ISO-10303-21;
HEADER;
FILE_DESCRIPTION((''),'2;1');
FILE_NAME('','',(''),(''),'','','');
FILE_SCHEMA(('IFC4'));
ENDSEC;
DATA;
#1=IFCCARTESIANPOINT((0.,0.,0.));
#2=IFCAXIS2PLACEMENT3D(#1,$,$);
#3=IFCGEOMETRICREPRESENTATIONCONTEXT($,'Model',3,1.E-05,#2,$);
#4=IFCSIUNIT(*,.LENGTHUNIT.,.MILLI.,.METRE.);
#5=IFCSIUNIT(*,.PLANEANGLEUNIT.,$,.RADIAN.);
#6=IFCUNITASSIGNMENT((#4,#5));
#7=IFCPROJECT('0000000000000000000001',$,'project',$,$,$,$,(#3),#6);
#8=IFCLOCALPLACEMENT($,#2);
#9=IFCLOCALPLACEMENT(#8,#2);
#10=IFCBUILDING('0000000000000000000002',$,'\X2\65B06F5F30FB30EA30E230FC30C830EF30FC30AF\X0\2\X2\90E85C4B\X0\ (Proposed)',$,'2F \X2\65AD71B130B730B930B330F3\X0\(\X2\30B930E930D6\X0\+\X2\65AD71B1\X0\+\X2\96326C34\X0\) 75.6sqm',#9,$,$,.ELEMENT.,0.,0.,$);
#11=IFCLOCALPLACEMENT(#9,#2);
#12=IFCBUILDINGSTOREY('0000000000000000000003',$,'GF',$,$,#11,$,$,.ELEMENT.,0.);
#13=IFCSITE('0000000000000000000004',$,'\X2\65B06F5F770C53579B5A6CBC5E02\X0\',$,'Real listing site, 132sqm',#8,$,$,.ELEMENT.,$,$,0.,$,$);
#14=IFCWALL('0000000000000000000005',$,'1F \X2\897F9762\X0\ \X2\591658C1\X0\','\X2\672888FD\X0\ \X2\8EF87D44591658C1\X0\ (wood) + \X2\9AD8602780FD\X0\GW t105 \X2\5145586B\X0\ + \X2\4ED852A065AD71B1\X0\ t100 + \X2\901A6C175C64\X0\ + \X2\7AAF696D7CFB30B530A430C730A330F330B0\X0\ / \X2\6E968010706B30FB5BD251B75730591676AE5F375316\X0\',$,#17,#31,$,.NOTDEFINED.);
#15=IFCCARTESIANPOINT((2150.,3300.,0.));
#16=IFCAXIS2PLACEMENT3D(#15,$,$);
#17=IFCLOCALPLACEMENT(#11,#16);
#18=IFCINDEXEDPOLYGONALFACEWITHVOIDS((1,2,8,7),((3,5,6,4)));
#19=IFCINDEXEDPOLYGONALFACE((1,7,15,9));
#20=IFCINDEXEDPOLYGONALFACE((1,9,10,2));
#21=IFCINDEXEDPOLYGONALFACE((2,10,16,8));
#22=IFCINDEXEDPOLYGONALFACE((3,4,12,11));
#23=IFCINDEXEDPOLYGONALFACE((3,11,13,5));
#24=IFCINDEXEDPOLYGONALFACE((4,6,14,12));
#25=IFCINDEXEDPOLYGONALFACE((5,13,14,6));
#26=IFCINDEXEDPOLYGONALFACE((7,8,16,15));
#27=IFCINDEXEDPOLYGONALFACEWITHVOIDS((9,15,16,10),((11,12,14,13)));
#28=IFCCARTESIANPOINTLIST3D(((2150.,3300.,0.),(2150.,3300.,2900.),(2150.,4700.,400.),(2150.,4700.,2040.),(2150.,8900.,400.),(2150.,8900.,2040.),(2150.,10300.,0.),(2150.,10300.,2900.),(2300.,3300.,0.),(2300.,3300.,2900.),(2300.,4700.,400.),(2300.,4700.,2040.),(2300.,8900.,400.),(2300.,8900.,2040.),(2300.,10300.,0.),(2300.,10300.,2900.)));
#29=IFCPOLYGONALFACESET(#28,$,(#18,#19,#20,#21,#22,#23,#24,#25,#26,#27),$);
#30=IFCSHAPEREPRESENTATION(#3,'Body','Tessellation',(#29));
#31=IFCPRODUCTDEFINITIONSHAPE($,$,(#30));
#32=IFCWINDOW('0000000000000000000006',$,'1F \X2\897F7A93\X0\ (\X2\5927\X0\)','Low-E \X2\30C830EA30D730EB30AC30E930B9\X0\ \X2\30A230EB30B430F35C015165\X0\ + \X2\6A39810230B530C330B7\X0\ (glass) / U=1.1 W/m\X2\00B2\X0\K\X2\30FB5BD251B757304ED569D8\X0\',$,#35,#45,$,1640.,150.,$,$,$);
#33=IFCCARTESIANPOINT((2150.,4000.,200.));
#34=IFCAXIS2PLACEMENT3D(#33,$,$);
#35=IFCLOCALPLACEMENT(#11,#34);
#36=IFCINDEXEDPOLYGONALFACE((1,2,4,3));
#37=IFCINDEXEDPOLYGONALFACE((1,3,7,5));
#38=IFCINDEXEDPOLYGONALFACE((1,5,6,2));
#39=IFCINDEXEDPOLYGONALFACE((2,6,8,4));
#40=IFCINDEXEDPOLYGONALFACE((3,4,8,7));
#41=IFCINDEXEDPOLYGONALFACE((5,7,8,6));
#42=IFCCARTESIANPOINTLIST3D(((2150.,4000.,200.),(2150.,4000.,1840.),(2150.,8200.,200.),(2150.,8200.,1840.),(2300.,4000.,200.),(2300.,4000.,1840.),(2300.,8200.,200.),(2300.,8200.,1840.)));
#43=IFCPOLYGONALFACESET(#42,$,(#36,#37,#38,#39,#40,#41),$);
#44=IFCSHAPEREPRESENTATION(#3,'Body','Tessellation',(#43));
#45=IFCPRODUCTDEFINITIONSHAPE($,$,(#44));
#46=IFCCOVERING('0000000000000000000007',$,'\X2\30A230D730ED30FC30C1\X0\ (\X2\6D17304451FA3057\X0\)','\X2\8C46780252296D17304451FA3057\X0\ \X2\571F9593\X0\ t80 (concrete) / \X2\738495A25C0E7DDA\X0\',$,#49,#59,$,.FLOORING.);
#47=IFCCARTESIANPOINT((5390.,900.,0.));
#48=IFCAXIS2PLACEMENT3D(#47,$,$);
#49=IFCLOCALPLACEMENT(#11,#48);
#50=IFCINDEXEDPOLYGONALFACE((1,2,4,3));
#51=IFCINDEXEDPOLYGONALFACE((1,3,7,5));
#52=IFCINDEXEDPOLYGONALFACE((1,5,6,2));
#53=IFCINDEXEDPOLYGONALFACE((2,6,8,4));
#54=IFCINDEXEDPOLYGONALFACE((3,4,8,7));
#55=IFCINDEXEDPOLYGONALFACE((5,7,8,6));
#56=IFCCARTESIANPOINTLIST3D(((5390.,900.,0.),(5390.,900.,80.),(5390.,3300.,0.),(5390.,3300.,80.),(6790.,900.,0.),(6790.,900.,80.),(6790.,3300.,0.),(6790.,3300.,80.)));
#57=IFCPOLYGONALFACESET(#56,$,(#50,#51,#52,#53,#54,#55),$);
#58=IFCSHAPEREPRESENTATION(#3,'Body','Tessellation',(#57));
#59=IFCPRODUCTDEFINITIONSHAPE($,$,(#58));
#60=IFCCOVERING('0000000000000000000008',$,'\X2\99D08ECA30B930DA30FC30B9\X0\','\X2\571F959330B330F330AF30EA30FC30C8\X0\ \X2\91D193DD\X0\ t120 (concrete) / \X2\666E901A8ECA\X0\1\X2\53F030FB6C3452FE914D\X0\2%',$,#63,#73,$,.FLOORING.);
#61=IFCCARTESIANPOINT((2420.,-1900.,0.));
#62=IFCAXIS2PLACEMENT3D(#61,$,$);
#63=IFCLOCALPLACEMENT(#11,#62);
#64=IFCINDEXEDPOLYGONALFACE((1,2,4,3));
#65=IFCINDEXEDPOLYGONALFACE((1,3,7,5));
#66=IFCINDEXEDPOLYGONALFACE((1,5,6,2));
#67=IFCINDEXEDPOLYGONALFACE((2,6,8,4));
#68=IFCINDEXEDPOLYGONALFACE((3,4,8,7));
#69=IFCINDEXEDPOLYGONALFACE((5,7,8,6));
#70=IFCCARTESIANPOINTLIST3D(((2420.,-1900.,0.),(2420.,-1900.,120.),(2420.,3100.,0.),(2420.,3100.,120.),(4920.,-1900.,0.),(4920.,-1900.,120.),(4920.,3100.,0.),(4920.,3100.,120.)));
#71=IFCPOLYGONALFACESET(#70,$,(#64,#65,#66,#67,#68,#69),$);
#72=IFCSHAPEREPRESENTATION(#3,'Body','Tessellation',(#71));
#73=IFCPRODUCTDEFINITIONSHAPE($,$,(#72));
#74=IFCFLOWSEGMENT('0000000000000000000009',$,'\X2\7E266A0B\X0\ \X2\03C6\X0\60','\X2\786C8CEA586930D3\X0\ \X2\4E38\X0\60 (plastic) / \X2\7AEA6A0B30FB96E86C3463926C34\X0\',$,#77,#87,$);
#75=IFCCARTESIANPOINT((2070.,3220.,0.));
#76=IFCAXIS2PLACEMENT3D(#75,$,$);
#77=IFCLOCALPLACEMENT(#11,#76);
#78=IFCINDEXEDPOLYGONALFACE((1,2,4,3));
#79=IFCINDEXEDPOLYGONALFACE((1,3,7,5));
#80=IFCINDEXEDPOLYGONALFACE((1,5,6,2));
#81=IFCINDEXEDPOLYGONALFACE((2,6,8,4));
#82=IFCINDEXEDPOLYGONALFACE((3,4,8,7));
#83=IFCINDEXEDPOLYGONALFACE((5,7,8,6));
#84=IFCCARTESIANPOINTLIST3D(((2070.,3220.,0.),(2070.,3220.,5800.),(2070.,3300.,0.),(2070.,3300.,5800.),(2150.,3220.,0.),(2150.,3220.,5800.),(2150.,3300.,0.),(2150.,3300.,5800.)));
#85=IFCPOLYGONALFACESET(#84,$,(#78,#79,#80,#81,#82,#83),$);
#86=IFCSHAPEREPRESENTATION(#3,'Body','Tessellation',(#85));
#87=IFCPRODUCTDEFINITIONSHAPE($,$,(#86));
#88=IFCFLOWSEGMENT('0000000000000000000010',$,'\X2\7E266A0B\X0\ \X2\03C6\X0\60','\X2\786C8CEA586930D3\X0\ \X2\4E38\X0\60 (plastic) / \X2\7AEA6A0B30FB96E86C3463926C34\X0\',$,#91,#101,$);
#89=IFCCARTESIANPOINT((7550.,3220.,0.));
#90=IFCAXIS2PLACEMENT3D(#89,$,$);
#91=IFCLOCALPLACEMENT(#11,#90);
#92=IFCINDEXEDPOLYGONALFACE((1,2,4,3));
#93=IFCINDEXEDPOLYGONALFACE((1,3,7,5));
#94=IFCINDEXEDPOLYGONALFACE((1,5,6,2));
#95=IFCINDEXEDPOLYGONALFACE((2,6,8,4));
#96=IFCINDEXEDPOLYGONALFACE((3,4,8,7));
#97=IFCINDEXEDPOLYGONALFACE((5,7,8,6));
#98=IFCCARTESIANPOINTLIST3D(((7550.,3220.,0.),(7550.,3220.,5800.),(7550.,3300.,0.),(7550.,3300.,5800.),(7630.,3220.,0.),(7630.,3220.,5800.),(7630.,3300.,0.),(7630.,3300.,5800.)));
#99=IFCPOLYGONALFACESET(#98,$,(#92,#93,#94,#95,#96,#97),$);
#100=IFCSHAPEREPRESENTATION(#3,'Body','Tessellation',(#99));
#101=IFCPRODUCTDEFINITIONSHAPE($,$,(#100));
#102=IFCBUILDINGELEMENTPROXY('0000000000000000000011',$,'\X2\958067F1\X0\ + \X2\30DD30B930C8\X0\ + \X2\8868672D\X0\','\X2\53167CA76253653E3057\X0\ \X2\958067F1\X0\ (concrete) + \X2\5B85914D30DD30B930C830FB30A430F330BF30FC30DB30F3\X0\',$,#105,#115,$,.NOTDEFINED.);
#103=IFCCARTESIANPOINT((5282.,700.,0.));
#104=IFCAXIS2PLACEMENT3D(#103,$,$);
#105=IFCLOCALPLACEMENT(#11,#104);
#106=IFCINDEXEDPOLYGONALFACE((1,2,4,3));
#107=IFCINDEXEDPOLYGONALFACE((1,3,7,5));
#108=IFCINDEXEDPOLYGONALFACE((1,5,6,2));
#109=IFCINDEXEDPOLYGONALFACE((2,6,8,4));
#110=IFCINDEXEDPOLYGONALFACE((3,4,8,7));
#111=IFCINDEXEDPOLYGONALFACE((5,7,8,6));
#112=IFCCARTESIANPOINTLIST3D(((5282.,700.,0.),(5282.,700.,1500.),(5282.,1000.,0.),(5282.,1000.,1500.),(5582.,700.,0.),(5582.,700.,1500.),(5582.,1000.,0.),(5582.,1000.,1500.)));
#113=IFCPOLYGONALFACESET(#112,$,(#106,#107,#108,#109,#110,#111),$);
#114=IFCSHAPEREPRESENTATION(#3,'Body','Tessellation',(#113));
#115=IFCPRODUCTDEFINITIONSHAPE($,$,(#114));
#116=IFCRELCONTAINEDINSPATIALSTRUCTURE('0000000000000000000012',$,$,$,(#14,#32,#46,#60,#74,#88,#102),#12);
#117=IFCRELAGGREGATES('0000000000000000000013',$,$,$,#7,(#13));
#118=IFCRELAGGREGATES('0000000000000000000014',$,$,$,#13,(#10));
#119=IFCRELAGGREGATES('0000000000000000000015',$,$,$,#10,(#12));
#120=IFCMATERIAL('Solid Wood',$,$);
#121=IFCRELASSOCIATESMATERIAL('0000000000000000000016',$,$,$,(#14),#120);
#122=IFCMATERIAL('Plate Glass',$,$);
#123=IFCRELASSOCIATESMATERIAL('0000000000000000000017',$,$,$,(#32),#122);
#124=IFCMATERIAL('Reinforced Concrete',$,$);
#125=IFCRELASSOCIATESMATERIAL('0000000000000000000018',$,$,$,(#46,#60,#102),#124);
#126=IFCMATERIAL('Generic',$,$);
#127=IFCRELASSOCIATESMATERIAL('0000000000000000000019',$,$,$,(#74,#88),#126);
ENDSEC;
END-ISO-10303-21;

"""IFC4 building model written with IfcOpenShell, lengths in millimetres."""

from ifc_helpers import new_model, si_unit, frame, frame_2d, origin, place, context, project, spatial, rectangle, extrude, material, element, fill, save


model = new_model("IFC4")

# Units and contexts
model_context = context("Model", 3, precision=1e-05, world=origin())
ifc_project = project(units=[si_unit("LENGTHUNIT", "METRE", prefix="MILLI"), si_unit("PLANEANGLEUNIT", "RADIAN")], contexts=[model_context])

# Site, building, storey
site_placement = place(None, origin())
site = spatial("IfcSite", under=ifc_project, at=site_placement, Name="新潟県南魚沼市", ObjectType="Real listing site, 132sqm", CompositionType="ELEMENT", RefElevation=0.0)
building_placement = place(site_placement, origin())
building = spatial("IfcBuilding", under=site, at=building_placement, Name="新潟・リモートワーク2部屋 (Proposed)", ObjectType="2F 断熱シスコン(スラブ+断熱+防水) 75.6sqm", CompositionType="ELEMENT", ElevationOfRefHeight=0.0, ElevationOfTerrain=0.0)
storey_placement = place(building_placement, origin())
storey = spatial("IfcBuildingStorey", under=building, at=storey_placement, Name="GF", CompositionType="ELEMENT", Elevation=0.0)

# Shared definitions
ifc_material_1 = material(Name="Solid Wood")

# Shared definitions
ifc_material_2 = material(Name="Reinforced Concrete")

# Shared definitions
ifc_material_3 = material(Name="Plate Glass")

# Wall, opening, window
wall_1_placement = place(storey_placement, frame((2150.0, 3300.0, 0.0)))
wall_1 = element("IfcWall", 1, at=wall_1_placement, inside=storey, material=ifc_material_1, Name="1F 西面 外壁", Description="木製 軸組外壁 (wood) + 高性能GW t105 充填 + 付加断熱 t100 + 通気層 + 窯業系サイディング / 準耐火・寒冷地外皮強化", PredefinedType="NOTDEFINED", context=model_context, shape_type="SweptSolid", body=[
    extrude(rectangle(XDim=150.0, YDim=7000.0, at=frame_2d((75.0, 3500.0))), frame((2150.0, 3300.0, 0.0)), (0.0, 0.0, 1.0), 2900.0),
])
opening_1_placement = place(storey_placement, frame((2150.0, 4000.0, 200.0)))
opening_1 = element("IfcOpeningElement", 2, at=opening_1_placement, cuts=wall_1, PredefinedType="NOTDEFINED", context=model_context, shape_type="SweptSolid", body=[
    extrude(rectangle(XDim=150.0, YDim=4200.0, at=frame_2d((75.0, 2100.0))), frame((2150.0, 4000.0, 200.0)), (0.0, 0.0, 1.0), 1640.0),
])
window_1_placement = place(storey_placement, frame((2150.0, 4000.0, 200.0)))
window_1 = element("IfcWindow", 3, at=window_1_placement, inside=storey, material=ifc_material_3, Name="1F 西窓 (大)", Description="Low-E トリプルガラス アルゴン封入 + 樹脂サッシ (glass) / U=1.1 W/m²K・寒冷地仕様", OverallHeight=1640.0, OverallWidth=150.0, context=model_context, shape_type="SweptSolid", body=[
    extrude(rectangle(XDim=150.0, YDim=4200.0, at=frame_2d((75.0, 2100.0))), frame((2150.0, 4000.0, 200.0)), (0.0, 0.0, 1.0), 1640.0),
])
fill(opening_1, window_1)

# Coverings
covering_1_placement = place(storey_placement, frame((5390.0, 900.0, 0.0)))
element("IfcCovering", 4, at=covering_1_placement, inside=storey, material=ifc_material_2, Name="アプローチ (洗い出し)", Description="豆砂利洗い出し 土間 t80 (concrete) / 玄関導線", PredefinedType="FLOORING", context=model_context, shape_type="SweptSolid", body=[
    extrude(rectangle(XDim=1400.0, YDim=2400.0, at=frame_2d((700.0, 1200.0))), frame((5390.0, 900.0, 0.0)), (0.0, 0.0, 1.0), 80.0),
])
covering_2_placement = place(storey_placement, frame((2420.0, -1900.0, 0.0)))
element("IfcCovering", 5, at=covering_2_placement, inside=storey, material=ifc_material_2, Name="駐車スペース", Description="土間コンクリート 金鏝 t120 (concrete) / 普通車1台・水勾配2%", PredefinedType="FLOORING", context=model_context, shape_type="SweptSolid", body=[
    extrude(rectangle(XDim=2500.0, YDim=5000.0, at=frame_2d((1250.0, 2500.0))), frame((2420.0, -1900.0, 0.0)), (0.0, 0.0, 1.0), 120.0),
])

# Flow segments
ifc_material_4 = material(Name="Generic")
flow_segment_1_placement = place(storey_placement, frame((2070.0, 3220.0, 0.0)))
element("IfcFlowSegment", 6, at=flow_segment_1_placement, inside=storey, material=ifc_material_4, Name="縦樋 φ60", Description="硬質塩ビ 丸60 (plastic) / 竪樋・雨水排水", context=model_context, shape_type="SweptSolid", body=[
    extrude(rectangle(XDim=80.0, YDim=80.0, at=frame_2d((40.0, 40.0))), frame((2070.0, 3220.0, 0.0)), (0.0, 0.0, 1.0), 5800.0),
])
flow_segment_2_placement = place(storey_placement, frame((7550.0, 3220.0, 0.0)))
element("IfcFlowSegment", 7, at=flow_segment_2_placement, inside=storey, material=ifc_material_4, Name="縦樋 φ60", Description="硬質塩ビ 丸60 (plastic) / 竪樋・雨水排水", context=model_context, shape_type="SweptSolid", body=[
    extrude(rectangle(XDim=80.0, YDim=80.0, at=frame_2d((40.0, 40.0))), frame((7550.0, 3220.0, 0.0)), (0.0, 0.0, 1.0), 5800.0),
])

# Building element proxy
proxy_placement = place(storey_placement, frame((5282.0, 700.0, 0.0)))
element("IfcBuildingElementProxy", 8, at=proxy_placement, inside=storey, material=ifc_material_2, Name="門柱 + ポスト + 表札", Description="化粧打放し 門柱 (concrete) + 宅配ポスト・インターホン", PredefinedType="NOTDEFINED", context=model_context, shape_type="SweptSolid", body=[
    extrude(rectangle(XDim=300.0, YDim=300.0, at=frame_2d((150.0, 150.0))), frame((5282.0, 700.0, 0.0)), (0.0, 0.0, 1.0), 1500.0),
])

save(model, "model.ifc")
